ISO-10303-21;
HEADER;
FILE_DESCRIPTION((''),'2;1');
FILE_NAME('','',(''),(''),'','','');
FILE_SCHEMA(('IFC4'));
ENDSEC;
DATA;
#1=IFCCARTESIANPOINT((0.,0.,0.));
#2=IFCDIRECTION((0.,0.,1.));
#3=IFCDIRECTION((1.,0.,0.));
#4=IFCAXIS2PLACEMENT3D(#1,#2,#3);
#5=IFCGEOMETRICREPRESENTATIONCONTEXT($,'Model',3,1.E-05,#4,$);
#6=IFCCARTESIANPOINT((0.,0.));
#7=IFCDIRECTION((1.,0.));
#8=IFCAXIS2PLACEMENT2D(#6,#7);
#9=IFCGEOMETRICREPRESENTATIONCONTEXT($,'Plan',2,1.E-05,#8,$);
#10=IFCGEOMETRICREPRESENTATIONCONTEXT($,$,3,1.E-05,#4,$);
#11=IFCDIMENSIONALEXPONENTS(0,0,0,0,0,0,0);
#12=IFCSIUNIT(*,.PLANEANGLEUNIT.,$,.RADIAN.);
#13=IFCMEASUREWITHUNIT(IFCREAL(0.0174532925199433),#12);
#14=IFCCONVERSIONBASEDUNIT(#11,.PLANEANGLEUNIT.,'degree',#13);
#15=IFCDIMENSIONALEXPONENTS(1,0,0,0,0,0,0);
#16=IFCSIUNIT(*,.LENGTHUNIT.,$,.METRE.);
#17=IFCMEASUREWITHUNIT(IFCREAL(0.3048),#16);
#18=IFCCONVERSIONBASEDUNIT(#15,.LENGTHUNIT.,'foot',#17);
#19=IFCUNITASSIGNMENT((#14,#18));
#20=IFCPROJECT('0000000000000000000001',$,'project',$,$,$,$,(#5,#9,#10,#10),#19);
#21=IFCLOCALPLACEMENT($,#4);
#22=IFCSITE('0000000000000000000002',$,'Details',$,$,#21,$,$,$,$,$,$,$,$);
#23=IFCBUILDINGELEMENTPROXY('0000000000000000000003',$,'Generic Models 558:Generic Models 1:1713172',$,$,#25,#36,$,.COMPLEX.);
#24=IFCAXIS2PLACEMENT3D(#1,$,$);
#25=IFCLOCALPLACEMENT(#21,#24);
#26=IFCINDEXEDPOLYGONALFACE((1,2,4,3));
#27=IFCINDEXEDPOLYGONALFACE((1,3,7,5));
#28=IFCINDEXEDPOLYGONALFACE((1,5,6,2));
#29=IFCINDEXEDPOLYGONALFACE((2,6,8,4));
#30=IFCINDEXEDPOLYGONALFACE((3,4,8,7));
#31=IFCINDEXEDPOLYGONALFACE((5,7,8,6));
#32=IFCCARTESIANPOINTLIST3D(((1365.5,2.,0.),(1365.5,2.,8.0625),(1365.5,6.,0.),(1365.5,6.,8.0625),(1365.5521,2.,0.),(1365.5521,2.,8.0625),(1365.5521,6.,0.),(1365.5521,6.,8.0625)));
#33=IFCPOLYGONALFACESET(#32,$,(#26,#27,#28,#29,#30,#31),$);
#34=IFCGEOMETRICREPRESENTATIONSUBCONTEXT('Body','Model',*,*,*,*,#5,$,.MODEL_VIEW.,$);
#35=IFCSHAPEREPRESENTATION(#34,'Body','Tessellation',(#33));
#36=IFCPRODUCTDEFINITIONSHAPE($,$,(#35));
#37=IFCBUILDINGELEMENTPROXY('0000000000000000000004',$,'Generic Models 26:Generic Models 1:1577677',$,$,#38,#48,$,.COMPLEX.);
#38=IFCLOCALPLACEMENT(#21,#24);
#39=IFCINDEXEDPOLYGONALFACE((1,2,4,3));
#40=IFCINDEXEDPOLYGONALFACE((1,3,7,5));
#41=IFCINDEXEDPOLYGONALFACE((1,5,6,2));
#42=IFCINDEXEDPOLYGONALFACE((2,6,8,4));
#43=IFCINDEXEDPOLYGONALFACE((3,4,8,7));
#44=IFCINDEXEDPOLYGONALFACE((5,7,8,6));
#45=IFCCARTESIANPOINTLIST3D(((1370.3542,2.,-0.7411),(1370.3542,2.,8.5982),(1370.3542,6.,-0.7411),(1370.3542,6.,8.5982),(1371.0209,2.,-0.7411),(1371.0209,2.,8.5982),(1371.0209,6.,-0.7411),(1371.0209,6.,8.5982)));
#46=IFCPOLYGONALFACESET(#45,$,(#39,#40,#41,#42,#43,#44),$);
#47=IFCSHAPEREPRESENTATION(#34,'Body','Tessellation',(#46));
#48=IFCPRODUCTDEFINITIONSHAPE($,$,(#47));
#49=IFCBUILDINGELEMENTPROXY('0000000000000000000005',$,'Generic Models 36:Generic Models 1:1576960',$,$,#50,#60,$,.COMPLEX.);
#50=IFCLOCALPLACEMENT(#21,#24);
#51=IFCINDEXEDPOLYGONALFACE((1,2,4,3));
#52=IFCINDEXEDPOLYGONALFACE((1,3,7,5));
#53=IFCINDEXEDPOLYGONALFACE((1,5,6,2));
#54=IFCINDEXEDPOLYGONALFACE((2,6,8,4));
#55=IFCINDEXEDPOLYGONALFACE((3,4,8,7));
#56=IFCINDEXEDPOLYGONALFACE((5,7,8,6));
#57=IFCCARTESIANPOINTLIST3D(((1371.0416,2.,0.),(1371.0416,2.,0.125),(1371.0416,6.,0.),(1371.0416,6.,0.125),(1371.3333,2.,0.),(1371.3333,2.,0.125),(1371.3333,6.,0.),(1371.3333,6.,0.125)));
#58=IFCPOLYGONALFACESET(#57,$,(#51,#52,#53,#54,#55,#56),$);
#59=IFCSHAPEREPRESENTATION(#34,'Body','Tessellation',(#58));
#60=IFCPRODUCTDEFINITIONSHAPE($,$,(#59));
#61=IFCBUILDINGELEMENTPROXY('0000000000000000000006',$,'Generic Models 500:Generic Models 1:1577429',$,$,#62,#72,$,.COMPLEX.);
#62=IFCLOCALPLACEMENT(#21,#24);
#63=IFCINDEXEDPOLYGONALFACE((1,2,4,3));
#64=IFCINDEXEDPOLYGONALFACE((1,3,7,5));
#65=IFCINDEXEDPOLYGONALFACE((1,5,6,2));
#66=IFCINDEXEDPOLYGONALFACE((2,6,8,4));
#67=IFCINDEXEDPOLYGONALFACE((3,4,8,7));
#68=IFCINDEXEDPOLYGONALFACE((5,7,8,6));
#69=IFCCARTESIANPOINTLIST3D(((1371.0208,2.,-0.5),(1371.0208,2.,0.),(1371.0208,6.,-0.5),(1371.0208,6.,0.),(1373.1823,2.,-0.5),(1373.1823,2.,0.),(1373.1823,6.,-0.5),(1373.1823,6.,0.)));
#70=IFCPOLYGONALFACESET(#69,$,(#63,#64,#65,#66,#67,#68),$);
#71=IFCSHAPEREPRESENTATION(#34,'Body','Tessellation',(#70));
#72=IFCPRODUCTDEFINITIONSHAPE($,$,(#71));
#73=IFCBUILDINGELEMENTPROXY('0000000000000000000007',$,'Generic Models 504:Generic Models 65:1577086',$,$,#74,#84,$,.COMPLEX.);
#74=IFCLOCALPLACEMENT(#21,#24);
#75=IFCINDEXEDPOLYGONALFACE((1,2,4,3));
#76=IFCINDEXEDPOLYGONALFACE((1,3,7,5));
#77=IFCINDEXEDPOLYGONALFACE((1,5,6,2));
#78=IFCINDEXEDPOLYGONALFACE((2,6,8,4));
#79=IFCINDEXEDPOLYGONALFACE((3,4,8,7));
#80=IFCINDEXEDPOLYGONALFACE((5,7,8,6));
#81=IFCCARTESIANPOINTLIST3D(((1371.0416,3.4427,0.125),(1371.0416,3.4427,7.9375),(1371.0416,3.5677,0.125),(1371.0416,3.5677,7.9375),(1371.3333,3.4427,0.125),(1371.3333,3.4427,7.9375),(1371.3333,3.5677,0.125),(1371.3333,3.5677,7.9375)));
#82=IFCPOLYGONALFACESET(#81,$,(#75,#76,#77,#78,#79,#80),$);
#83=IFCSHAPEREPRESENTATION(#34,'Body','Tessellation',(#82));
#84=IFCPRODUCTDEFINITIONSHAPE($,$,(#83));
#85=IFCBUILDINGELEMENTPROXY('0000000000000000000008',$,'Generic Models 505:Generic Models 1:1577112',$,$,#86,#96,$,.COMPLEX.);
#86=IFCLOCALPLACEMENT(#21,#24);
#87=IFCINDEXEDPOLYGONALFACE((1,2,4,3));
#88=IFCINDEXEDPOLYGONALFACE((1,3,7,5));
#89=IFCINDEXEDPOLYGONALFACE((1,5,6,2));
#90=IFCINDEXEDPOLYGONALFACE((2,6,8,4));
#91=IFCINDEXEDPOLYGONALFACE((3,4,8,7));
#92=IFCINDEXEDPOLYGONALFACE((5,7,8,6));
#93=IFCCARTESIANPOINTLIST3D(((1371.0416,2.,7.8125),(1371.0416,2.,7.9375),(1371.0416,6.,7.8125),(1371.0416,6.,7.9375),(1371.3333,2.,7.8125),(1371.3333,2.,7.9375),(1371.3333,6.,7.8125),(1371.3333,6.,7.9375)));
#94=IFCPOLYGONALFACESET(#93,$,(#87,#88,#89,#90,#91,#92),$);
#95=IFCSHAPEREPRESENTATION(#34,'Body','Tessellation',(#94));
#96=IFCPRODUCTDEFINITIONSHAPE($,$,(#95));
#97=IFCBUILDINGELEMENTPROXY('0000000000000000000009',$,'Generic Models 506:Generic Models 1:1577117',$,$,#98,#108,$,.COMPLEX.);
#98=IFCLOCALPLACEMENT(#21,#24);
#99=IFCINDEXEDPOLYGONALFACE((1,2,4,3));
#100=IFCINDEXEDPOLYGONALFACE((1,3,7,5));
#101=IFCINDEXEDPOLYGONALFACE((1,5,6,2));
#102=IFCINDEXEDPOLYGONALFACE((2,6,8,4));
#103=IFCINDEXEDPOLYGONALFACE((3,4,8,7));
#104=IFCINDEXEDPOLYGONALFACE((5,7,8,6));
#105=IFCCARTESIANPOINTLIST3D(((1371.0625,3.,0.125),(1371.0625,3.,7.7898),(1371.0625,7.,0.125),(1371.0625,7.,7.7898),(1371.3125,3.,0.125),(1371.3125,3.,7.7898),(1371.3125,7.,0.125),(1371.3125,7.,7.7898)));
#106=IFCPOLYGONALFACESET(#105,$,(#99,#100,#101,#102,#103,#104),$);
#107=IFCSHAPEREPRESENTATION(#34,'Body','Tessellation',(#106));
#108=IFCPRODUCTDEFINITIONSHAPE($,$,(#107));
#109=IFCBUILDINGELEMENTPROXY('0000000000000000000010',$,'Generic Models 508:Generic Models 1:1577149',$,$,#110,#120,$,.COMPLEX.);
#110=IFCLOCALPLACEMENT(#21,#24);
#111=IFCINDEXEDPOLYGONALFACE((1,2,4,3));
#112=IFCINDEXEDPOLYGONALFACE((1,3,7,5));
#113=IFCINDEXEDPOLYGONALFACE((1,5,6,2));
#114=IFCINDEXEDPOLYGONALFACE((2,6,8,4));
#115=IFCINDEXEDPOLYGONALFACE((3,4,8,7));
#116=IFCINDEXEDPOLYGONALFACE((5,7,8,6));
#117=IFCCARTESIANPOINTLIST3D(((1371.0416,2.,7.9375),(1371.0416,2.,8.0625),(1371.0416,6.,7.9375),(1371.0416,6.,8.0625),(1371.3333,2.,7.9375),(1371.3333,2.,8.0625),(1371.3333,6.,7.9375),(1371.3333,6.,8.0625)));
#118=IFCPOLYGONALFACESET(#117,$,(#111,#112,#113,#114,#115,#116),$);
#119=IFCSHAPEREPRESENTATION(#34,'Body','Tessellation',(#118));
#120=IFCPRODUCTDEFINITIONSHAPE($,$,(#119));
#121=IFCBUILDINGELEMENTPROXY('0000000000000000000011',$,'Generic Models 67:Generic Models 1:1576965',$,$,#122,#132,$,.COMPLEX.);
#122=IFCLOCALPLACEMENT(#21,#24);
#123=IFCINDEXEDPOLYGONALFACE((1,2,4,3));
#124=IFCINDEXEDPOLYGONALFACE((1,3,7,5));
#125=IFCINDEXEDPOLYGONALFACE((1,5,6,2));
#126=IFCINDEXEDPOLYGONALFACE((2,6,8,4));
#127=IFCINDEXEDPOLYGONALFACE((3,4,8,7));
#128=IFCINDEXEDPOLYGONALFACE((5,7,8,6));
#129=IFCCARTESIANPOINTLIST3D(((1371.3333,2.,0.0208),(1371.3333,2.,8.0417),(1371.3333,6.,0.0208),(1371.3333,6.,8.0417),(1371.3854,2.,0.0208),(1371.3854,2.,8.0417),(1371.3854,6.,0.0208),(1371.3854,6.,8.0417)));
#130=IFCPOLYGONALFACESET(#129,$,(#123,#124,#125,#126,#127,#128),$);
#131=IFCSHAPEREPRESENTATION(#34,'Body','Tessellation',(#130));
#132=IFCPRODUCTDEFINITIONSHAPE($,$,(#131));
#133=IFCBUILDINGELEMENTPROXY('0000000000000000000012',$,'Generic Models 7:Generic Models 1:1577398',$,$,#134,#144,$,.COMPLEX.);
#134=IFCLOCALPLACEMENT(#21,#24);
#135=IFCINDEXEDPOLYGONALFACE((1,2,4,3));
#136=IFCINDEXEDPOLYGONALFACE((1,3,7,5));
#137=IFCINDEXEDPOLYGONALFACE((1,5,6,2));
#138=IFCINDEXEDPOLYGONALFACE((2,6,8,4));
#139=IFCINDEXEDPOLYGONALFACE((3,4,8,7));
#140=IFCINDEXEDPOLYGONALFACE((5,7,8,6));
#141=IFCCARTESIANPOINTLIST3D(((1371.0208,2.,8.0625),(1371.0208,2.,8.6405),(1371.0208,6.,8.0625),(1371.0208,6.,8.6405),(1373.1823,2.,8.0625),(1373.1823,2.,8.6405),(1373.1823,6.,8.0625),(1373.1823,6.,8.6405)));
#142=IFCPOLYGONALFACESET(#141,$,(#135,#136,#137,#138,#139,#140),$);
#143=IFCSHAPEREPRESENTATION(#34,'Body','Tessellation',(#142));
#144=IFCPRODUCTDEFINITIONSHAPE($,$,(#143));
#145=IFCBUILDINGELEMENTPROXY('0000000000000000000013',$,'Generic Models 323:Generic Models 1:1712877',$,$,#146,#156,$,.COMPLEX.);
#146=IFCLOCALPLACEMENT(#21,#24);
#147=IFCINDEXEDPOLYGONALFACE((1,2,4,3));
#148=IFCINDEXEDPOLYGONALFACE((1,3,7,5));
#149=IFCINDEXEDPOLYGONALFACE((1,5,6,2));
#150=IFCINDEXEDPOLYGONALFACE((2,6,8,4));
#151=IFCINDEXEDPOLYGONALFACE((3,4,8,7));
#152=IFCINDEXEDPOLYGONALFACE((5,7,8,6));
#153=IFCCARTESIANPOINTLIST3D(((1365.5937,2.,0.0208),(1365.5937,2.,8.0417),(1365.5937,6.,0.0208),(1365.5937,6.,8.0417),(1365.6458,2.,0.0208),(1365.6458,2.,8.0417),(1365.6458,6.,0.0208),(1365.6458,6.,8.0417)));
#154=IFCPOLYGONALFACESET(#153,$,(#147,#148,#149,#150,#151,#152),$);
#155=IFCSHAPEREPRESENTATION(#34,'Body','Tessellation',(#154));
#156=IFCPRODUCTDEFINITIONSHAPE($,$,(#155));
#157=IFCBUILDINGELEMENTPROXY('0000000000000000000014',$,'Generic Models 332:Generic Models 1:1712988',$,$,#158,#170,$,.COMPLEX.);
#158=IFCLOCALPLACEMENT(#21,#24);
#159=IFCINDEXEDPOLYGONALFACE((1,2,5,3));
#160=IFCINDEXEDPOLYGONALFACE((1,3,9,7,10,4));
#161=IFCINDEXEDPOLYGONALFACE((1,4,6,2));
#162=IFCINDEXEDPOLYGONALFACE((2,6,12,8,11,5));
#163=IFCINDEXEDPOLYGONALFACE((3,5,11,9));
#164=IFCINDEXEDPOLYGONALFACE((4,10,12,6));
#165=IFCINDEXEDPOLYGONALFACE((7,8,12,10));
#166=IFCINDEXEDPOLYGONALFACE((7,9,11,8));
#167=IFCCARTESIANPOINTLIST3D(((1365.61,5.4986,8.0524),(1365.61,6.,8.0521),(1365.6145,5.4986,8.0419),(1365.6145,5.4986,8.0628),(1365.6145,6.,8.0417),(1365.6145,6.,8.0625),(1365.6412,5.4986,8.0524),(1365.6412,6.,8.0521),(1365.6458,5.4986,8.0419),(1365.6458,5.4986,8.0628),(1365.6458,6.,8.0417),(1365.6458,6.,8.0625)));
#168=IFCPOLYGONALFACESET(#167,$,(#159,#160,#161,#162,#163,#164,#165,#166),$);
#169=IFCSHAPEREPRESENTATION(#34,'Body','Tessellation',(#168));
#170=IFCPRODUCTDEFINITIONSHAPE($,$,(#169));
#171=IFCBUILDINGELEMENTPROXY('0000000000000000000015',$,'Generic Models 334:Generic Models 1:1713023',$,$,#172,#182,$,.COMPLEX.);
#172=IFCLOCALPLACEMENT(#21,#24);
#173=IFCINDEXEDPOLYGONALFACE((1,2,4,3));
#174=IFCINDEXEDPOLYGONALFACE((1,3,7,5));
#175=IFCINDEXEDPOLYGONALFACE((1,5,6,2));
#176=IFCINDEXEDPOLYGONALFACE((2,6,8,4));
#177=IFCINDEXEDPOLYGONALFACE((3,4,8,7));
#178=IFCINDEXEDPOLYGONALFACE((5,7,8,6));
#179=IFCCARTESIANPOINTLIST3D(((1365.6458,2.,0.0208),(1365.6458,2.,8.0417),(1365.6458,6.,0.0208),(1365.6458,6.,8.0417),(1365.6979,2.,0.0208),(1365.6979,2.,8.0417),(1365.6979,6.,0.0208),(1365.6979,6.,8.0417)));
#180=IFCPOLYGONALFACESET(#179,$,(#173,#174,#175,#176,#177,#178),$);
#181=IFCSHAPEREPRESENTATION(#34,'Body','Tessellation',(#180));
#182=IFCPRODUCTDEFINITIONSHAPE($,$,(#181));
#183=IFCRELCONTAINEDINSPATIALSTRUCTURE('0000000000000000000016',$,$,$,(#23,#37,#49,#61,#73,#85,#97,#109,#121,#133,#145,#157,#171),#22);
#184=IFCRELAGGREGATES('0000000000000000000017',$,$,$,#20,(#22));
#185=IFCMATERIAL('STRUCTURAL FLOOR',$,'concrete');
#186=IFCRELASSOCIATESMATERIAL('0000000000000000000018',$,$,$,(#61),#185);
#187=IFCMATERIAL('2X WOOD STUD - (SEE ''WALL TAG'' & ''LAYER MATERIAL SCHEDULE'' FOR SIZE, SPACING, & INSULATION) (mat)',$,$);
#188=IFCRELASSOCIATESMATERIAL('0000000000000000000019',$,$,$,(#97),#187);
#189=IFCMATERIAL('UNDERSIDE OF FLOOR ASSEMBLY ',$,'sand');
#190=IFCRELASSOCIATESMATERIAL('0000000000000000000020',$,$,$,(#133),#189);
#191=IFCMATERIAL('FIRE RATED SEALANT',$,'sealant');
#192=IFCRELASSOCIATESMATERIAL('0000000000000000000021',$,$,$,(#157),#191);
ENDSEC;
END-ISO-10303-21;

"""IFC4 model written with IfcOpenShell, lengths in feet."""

from ifc_helpers import new_model, entity, si_unit, converted_unit, frame, origin_with_axes, origin_2d_with_axis, place, context, subcontext, project, spatial, polyline, outline, extrude, material, element, save


model = new_model("IFC4")

# Units and contexts
model_context = context("Model", 3, precision=1e-05, world=origin_with_axes())
plan_context = context("Plan", 2, precision=1e-05, world=origin_2d_with_axis())
context_of_model = context(None, 3, precision=1e-05, world=origin_with_axes())
body_context = subcontext(model_context, "Body", "Model", "MODEL_VIEW")
ifc_project = project(units=[converted_unit("PLANEANGLEUNIT", "degree", entity("IfcReal", 0.0174532925199433), si_unit("PLANEANGLEUNIT", "RADIAN"), dimensions=[0, 0, 0, 0, 0, 0, 0]), converted_unit("LENGTHUNIT", "foot", entity("IfcReal", 0.3048), si_unit("LENGTHUNIT", "METRE"), dimensions=[1, 0, 0, 0, 0, 0, 0])], contexts=[model_context, plan_context, context_of_model, context_of_model])

# Site
site_placement = place(None, origin_with_axes())
site = spatial("IfcSite", under=ifc_project, at=site_placement, Name="Details")

# Building element proxies
proxy_1_placement = place(site_placement, frame((1365.5, 6.0, 0.0), z_axis=(0.0, -1.0, 0.0), x_axis=(0.0, 0.0, 1.0)))
element("IfcBuildingElementProxy", 1, at=proxy_1_placement, inside=site, Name="Generic Models 558:Generic Models 1:1713172", PredefinedType="COMPLEX", context=body_context, shape_type="SweptSolid", body=[
    extrude(outline(polyline([(-4.0312, -0.026), (4.0312, -0.026), (4.0312, 0.026), (-4.0312, 0.026), (-4.0312, -0.026)])), frame((4.0312, -0.026, 0.0), z_axis=(0.0, 0.0, -1.0), x_axis=(1.0, 0.0, 0.0)), (0.0, 0.0, -1.0), 4.0),
])
proxy_2_placement = place(site_placement, frame((1370.3542, 6.0, -0.7411), z_axis=(0.0, -1.0, 0.0), x_axis=(0.0, 0.0, -1.0)))
element("IfcBuildingElementProxy", 2, at=proxy_2_placement, inside=site, Name="Generic Models 26:Generic Models 1:1577677", PredefinedType="COMPLEX", context=body_context, shape_type="SweptSolid", body=[
    extrude(outline(polyline([(-0.3333, -4.6697), (0.3333, -4.6697), (0.3333, 4.6697), (-0.3333, 4.6697), (-0.3333, -4.6697)])), frame((-4.6697, 0.3333, 0.0), z_axis=(0.0, 0.0, -1.0), x_axis=(0.0, -1.0, 0.0)), (0.0, 0.0, -1.0), 4.0),
])
proxy_3_placement = place(site_placement, frame((1371.0416, 6.0, 0.0), z_axis=(0.0, -1.0, 0.0), x_axis=(0.0, 0.0, -1.0)))
element("IfcBuildingElementProxy", 3, at=proxy_3_placement, inside=site, Name="Generic Models 36:Generic Models 1:1576960", PredefinedType="COMPLEX", context=body_context, shape_type="SweptSolid", body=[
    extrude(outline(polyline([(-0.0625, -0.1458), (0.0625, -0.1458), (0.0625, 0.1458), (-0.0625, 0.1458), (-0.0625, -0.1458)])), frame((-0.0625, 0.1458, 0.0), z_axis=(0.0, 0.0, -1.0), x_axis=(1.0, 0.0, 0.0)), (0.0, 0.0, -1.0), 4.0),
])
ifc_material_1 = material(Name="STRUCTURAL FLOOR", Category="concrete")
proxy_4_placement = place(site_placement, frame((1371.0208, 6.0, -0.5), z_axis=(0.0, -1.0, 0.0), x_axis=(0.0, 0.0, -1.0)))
element("IfcBuildingElementProxy", 4, at=proxy_4_placement, inside=site, material=ifc_material_1, Name="Generic Models 500:Generic Models 1:1577429", PredefinedType="COMPLEX", context=body_context, shape_type="SweptSolid", body=[
    extrude(outline(polyline([(-0.25, -1.0807), (0.25, -1.0807), (0.25, 1.0807), (-0.25, 1.0807), (-0.25, -1.0807)])), frame((-0.25, 1.0807, 0.0), z_axis=(0.0, 0.0, -1.0), x_axis=(1.0, 0.0, 0.0)), (0.0, 0.0, -1.0), 4.0),
])
proxy_5_placement = place(site_placement, frame((1371.0416, 3.4427, 0.125), z_axis=(1.0, 0.0, 0.0), x_axis=(0.0, 0.0, -1.0)))
element("IfcBuildingElementProxy", 5, at=proxy_5_placement, inside=site, Name="Generic Models 504:Generic Models 65:1577086", PredefinedType="COMPLEX", context=body_context, shape_type="SweptSolid", body=[
    extrude(outline(polyline([(-3.9062, -0.0625), (3.9062, -0.0625), (3.9062, 0.0625), (-3.9062, 0.0625), (-3.9062, -0.0625)])), frame((-3.9062, 0.0625, 0.0), z_axis=(0.0, 0.0, -1.0), x_axis=(1.0, 0.0, 0.0)), (0.0, 0.0, -1.0), 0.2917),
])
proxy_6_placement = place(site_placement, frame((1371.0416, 6.0, 7.8125), z_axis=(0.0, -1.0, 0.0), x_axis=(0.0, 0.0, -1.0)))
element("IfcBuildingElementProxy", 6, at=proxy_6_placement, inside=site, Name="Generic Models 505:Generic Models 1:1577112", PredefinedType="COMPLEX", context=body_context, shape_type="SweptSolid", body=[
    extrude(outline(polyline([(-0.0625, -0.1458), (0.0625, -0.1458), (0.0625, 0.1458), (-0.0625, 0.1458), (-0.0625, -0.1458)])), frame((-0.0625, 0.1458, 0.0), z_axis=(0.0, 0.0, -1.0), x_axis=(1.0, 0.0, 0.0)), (0.0, 0.0, -1.0), 4.0),
])
ifc_material_2 = material(Name="2X WOOD STUD - (SEE 'WALL TAG' & 'LAYER MATERIAL SCHEDULE' FOR SIZE, SPACING, & INSULATION) (mat)")
proxy_7_placement = place(site_placement, frame((1371.0625, 3.0, 0.125), z_axis=(0.0, 1.0, 0.0), x_axis=(0.0, 0.0, -1.0)))
element("IfcBuildingElementProxy", 7, at=proxy_7_placement, inside=site, material=ifc_material_2, Name="Generic Models 506:Generic Models 1:1577117", PredefinedType="COMPLEX", context=body_context, shape_type="SweptSolid", body=[
    extrude(outline(polyline([(-3.8324, -0.125), (3.8324, -0.125), (3.8324, 0.125), (-3.8324, 0.125), (-3.8324, -0.125)])), frame((-3.8324, -0.125, 0.0), z_axis=(0.0, 0.0, -1.0), x_axis=(1.0, 0.0, 0.0)), (0.0, 0.0, -1.0), 4.0),
])
proxy_8_placement = place(site_placement, frame((1371.0416, 6.0, 7.9375), z_axis=(0.0, -1.0, 0.0), x_axis=(0.0, 0.0, -1.0)))
element("IfcBuildingElementProxy", 8, at=proxy_8_placement, inside=site, Name="Generic Models 508:Generic Models 1:1577149", PredefinedType="COMPLEX", context=body_context, shape_type="SweptSolid", body=[
    extrude(outline(polyline([(-0.0625, -0.1458), (0.0625, -0.1458), (0.0625, 0.1458), (-0.0625, 0.1458), (-0.0625, -0.1458)])), frame((-0.0625, 0.1458, 0.0), z_axis=(0.0, 0.0, -1.0), x_axis=(1.0, 0.0, 0.0)), (0.0, 0.0, -1.0), 4.0),
])
proxy_9_placement = place(site_placement, frame((1371.3333, 6.0, 0.0208), z_axis=(0.0, -1.0, 0.0), x_axis=(0.0, 0.0, -1.0)))
element("IfcBuildingElementProxy", 9, at=proxy_9_placement, inside=site, Name="Generic Models 67:Generic Models 1:1576965", PredefinedType="COMPLEX", context=body_context, shape_type="SweptSolid", body=[
    extrude(outline(polyline([(-0.026, -4.0104), (0.026, -4.0104), (0.026, 4.0104), (-0.026, 4.0104), (-0.026, -4.0104)])), frame((-4.0104, 0.026, 0.0), z_axis=(0.0, 0.0, -1.0), x_axis=(0.0, 1.0, 0.0)), (0.0, 0.0, -1.0), 4.0),
])
ifc_material_3 = material(Name="UNDERSIDE OF FLOOR ASSEMBLY ", Category="sand")
proxy_10_placement = place(site_placement, frame((1371.0208, 6.0, 8.0625), z_axis=(0.0, -1.0, 0.0), x_axis=(0.0, 0.0, -1.0)))
element("IfcBuildingElementProxy", 10, at=proxy_10_placement, inside=site, material=ifc_material_3, Name="Generic Models 7:Generic Models 1:1577398", PredefinedType="COMPLEX", context=body_context, shape_type="SweptSolid", body=[
    extrude(outline(polyline([(-0.289, -1.0807), (0.289, -1.0807), (0.289, 1.0807), (-0.289, 1.0807), (-0.289, -1.0807)])), frame((-0.289, 1.0807, 0.0), z_axis=(0.0, 0.0, -1.0), x_axis=(-1.0, 0.0, 0.0)), (0.0, 0.0, -1.0), 4.0),
])
proxy_11_placement = place(site_placement, frame((1365.5937, 6.0, 0.0208), z_axis=(0.0, -1.0, 0.0), x_axis=(0.0, 0.0, 1.0)))
element("IfcBuildingElementProxy", 11, at=proxy_11_placement, inside=site, Name="Generic Models 323:Generic Models 1:1712877", PredefinedType="COMPLEX", context=body_context, shape_type="SweptSolid", body=[
    extrude(outline(polyline([(-4.0104, -0.026), (4.0104, -0.026), (4.0104, 0.026), (-4.0104, 0.026), (-4.0104, -0.026)])), frame((4.0104, -0.026, 0.0), z_axis=(0.0, 0.0, -1.0), x_axis=(1.0, 0.0, 0.0)), (0.0, 0.0, -1.0), 4.0),
])
ifc_material_4 = material(Name="FIRE RATED SEALANT", Category="sealant")
proxy_12_placement = place(site_placement, frame((1365.6101, 6.0, 8.0417), z_axis=(0.0, -1.0, 0.0), x_axis=(0.0, 0.0, 1.0)))
element("IfcBuildingElementProxy", 12, at=proxy_12_placement, inside=site, material=ifc_material_4, Name="Generic Models 332:Generic Models 1:1712988", PredefinedType="COMPLEX", context=body_context, shape_type="SweptSolid", body=[
    extrude(outline(polyline([(0.0201, 0.0), (0.0107, 0.0065), (0.0093, 0.0178), (-0.0175, 0.0016), (-0.016, -0.0097), (-0.0066, -0.0162), (0.0201, 0.0)])), frame((0.0104, -0.0186, 0.0), z_axis=(0.0, 0.0, -1.0), x_axis=(0.51911, -0.854707, 0.0)), (0.000294, -0.000474, -1.0), 0.5014),
])
proxy_13_placement = place(site_placement, frame((1365.6458, 6.0, 0.0208), z_axis=(0.0, -1.0, 0.0), x_axis=(0.0, 0.0, 1.0)))
element("IfcBuildingElementProxy", 13, at=proxy_13_placement, inside=site, Name="Generic Models 334:Generic Models 1:1713023", PredefinedType="COMPLEX", context=body_context, shape_type="SweptSolid", body=[
    extrude(outline(polyline([(-4.0104, -0.026), (4.0104, -0.026), (4.0104, 0.026), (-4.0104, 0.026), (-4.0104, -0.026)])), frame((4.0104, -0.026, 0.0), z_axis=(0.0, 0.0, -1.0), x_axis=(1.0, 0.0, 0.0)), (0.0, 0.0, -1.0), 4.0),
])

save(model, "model.ifc")
